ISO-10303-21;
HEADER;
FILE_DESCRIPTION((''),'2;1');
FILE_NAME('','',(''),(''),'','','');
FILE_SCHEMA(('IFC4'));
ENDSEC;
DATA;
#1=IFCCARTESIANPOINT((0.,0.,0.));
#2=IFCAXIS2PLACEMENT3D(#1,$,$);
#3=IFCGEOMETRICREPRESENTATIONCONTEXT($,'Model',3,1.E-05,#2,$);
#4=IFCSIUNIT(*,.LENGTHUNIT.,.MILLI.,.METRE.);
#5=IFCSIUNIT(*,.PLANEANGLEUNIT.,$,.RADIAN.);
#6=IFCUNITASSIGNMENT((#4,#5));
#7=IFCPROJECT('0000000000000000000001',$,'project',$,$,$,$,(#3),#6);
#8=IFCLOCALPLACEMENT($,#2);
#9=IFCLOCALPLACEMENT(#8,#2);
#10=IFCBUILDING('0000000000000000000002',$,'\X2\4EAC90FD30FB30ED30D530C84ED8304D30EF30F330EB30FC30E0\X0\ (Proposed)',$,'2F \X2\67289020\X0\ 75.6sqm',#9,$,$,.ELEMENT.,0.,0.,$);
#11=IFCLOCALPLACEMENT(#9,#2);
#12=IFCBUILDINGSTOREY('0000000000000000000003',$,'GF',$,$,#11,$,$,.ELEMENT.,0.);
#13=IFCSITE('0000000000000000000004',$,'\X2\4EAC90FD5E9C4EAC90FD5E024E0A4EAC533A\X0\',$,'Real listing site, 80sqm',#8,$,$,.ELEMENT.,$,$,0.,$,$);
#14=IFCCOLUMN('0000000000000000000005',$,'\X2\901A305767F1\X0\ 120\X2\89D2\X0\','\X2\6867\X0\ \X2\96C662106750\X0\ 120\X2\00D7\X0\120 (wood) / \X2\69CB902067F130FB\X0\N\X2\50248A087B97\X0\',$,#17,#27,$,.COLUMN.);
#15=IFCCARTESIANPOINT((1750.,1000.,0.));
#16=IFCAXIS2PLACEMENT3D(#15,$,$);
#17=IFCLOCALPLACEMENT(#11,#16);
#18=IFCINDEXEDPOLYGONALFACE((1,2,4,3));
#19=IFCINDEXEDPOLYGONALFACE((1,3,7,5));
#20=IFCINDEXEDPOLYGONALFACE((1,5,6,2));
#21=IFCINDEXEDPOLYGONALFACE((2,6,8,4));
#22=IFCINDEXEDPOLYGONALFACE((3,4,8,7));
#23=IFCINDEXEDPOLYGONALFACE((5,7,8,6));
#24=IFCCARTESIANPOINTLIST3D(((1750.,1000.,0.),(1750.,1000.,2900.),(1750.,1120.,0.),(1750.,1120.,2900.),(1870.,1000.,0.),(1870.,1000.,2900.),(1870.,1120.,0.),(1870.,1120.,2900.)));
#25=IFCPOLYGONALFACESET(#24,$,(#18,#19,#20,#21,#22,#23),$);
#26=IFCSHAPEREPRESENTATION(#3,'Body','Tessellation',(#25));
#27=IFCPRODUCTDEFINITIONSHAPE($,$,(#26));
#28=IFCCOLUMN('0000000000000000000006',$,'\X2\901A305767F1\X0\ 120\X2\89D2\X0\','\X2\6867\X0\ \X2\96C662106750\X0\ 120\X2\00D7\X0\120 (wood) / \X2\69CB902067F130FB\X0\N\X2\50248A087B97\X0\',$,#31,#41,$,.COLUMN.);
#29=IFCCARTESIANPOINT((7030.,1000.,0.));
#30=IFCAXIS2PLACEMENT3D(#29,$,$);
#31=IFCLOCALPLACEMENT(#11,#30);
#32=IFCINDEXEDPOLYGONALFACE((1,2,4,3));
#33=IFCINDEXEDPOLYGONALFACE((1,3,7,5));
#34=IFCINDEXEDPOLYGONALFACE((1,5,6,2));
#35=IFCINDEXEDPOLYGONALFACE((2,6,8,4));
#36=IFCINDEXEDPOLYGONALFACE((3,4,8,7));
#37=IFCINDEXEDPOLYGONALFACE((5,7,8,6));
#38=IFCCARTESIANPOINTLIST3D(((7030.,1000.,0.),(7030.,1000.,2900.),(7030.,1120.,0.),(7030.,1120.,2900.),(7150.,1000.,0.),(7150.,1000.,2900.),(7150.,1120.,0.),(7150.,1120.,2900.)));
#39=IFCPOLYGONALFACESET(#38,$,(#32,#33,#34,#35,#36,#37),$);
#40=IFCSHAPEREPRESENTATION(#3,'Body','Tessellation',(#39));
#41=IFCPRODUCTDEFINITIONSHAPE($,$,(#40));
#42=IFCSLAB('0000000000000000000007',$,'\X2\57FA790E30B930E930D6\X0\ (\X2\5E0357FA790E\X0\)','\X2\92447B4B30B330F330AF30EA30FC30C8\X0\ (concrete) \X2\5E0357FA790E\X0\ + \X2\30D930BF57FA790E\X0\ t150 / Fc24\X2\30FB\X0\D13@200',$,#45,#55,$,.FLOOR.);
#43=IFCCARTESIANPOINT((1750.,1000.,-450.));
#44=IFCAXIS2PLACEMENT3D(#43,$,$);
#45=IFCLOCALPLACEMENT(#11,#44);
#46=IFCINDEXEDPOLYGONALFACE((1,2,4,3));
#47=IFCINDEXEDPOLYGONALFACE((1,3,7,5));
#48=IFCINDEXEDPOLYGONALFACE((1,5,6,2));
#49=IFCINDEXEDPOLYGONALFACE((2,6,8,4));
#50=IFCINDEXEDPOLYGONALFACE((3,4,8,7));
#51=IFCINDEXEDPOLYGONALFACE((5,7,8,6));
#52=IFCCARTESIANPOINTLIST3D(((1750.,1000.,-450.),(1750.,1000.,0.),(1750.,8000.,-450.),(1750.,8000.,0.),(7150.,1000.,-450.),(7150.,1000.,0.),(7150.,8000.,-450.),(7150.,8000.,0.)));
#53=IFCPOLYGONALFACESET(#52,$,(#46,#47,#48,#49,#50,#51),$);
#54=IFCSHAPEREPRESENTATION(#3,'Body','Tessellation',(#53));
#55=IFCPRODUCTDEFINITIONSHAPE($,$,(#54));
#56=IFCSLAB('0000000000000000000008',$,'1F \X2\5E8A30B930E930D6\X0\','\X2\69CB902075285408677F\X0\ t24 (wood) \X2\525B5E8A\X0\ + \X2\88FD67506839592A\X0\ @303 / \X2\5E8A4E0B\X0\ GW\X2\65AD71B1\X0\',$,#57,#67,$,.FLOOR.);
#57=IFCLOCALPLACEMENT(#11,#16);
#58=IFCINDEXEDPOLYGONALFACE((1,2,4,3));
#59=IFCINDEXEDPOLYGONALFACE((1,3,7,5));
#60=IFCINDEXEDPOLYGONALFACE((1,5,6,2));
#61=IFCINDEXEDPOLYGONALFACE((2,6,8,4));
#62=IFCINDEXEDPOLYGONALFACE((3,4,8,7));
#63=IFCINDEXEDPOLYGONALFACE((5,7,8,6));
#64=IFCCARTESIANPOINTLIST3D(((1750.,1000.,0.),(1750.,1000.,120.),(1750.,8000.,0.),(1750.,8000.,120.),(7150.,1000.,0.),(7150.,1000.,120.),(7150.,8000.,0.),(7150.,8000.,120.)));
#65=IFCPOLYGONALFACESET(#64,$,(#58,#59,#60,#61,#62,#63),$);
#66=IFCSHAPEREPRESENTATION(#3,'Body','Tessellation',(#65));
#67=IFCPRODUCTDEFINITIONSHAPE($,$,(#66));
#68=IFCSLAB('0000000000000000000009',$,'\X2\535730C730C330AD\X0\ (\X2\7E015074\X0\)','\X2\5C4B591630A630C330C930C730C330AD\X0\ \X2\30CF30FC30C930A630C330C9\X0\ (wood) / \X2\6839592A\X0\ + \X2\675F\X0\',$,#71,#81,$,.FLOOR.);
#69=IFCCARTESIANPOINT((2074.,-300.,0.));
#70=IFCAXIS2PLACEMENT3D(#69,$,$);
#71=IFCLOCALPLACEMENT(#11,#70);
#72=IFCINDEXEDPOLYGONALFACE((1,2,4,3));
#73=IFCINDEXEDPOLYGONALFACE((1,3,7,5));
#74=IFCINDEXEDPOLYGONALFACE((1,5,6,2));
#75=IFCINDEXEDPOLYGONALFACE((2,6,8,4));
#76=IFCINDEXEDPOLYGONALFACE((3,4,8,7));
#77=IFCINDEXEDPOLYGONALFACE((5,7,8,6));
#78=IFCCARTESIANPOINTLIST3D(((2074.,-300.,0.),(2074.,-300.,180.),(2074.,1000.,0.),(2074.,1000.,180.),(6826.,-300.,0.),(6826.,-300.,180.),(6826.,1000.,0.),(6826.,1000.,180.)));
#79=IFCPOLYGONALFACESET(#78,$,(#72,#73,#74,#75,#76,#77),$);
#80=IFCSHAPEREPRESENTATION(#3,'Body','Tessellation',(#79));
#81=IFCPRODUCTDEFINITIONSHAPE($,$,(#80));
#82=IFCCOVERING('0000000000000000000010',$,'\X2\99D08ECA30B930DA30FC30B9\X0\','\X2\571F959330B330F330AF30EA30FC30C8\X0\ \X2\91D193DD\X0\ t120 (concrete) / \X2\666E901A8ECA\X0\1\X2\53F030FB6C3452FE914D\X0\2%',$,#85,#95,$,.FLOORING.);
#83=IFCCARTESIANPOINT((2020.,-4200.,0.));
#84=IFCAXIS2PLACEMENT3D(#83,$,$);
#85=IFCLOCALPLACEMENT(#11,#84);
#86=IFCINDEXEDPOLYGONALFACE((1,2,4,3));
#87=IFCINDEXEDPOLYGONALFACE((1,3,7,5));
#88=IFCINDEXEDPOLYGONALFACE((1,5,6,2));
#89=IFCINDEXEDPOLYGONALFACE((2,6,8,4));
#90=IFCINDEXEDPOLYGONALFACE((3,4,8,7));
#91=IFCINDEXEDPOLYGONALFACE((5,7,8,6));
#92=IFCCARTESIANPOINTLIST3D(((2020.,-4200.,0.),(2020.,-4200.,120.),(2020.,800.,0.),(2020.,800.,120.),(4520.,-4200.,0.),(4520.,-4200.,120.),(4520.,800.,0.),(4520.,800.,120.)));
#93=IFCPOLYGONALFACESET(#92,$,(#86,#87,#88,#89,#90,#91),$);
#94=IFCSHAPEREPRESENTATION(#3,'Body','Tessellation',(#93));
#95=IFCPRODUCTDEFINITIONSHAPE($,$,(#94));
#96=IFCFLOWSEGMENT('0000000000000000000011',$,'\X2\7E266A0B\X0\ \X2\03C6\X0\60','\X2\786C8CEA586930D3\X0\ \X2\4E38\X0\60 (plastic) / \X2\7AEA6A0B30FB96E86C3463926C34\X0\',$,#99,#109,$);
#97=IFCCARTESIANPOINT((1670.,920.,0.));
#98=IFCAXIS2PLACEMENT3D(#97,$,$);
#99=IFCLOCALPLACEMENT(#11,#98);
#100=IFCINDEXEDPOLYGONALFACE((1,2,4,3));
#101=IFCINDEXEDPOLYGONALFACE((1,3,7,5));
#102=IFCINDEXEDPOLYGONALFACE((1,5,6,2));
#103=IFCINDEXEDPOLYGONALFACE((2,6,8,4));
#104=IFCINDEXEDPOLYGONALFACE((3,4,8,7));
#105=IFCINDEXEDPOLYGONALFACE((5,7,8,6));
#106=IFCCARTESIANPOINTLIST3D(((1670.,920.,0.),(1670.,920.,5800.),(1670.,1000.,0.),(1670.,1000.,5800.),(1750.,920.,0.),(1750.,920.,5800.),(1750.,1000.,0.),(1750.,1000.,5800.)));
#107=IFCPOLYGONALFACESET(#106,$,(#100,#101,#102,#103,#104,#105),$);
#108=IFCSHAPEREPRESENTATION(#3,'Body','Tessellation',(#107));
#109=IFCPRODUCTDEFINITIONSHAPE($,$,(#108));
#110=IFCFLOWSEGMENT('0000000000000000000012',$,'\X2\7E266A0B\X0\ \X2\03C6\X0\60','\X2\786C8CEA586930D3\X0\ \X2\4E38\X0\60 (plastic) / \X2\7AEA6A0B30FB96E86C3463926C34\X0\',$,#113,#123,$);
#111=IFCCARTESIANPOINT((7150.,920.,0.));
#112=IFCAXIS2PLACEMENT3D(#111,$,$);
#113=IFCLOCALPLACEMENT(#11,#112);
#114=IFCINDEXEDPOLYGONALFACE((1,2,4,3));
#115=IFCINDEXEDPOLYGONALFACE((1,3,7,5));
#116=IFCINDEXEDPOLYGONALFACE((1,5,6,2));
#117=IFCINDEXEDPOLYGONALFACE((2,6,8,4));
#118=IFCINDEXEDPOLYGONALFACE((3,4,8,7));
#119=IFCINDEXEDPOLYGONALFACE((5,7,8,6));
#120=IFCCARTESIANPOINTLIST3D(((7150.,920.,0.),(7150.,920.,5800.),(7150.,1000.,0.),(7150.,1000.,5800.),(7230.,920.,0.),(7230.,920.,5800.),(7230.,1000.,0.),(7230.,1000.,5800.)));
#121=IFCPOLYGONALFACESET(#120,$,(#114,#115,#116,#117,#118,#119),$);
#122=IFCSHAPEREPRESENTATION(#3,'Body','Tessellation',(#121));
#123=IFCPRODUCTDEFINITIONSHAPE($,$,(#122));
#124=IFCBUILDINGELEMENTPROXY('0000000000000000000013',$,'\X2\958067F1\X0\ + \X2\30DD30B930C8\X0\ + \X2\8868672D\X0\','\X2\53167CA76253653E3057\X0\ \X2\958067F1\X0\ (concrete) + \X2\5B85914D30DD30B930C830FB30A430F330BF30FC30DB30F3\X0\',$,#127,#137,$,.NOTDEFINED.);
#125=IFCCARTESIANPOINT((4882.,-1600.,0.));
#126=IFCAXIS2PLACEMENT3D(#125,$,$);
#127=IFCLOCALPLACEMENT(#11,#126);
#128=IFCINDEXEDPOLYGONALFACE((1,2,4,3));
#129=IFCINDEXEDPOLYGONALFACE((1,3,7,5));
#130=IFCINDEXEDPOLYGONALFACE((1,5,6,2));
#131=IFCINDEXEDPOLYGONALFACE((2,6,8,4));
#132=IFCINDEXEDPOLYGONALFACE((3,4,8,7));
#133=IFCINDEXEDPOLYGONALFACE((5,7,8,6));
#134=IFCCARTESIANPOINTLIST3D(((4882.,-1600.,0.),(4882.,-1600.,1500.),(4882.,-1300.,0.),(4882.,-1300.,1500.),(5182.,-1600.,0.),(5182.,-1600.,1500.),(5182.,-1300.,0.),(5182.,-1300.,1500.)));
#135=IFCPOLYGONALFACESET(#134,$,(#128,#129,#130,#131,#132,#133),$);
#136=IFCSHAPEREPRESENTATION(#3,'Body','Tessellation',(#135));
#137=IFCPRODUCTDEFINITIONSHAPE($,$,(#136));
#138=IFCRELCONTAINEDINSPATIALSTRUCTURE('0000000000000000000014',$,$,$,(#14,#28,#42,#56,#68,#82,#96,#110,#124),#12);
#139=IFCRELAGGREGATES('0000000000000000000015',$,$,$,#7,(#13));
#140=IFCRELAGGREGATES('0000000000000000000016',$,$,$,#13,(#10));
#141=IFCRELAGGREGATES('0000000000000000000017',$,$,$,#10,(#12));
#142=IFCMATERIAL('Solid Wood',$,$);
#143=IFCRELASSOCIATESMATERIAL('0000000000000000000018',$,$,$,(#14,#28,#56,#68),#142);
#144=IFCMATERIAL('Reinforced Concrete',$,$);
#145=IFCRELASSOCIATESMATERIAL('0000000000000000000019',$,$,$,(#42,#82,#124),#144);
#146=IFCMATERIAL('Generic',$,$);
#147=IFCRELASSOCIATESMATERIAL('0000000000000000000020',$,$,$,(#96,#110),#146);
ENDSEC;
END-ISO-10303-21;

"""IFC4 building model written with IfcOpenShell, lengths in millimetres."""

from ifc_helpers import new_model, si_unit, frame, frame_2d, origin, place, context, project, spatial, rectangle, extrude, material, element, save


model = new_model("IFC4")

# Units and contexts
model_context = context("Model", 3, precision=1e-05, world=origin())
ifc_project = project(units=[si_unit("LENGTHUNIT", "METRE", prefix="MILLI"), si_unit("PLANEANGLEUNIT", "RADIAN")], contexts=[model_context])

# Site, building, storey
site_placement = place(None, origin())
site = spatial("IfcSite", under=ifc_project, at=site_placement, Name="京都府京都市上京区", ObjectType="Real listing site, 80sqm", CompositionType="ELEMENT", RefElevation=0.0)
building_placement = place(site_placement, origin())
building = spatial("IfcBuilding", under=site, at=building_placement, Name="京都・ロフト付きワンルーム (Proposed)", ObjectType="2F 木造 75.6sqm", CompositionType="ELEMENT", ElevationOfRefHeight=0.0, ElevationOfTerrain=0.0)
storey_placement = place(building_placement, origin())
storey = spatial("IfcBuildingStorey", under=building, at=storey_placement, Name="GF", CompositionType="ELEMENT", Elevation=0.0)

# Columns
ifc_material_1 = material(Name="Solid Wood")
column_1_placement = place(storey_placement, frame((1750.0, 1000.0, 0.0)))
element("IfcColumn", 1, at=column_1_placement, inside=storey, material=ifc_material_1, Name="通し柱 120角", Description="桧 集成材 120×120 (wood) / 構造柱・N値計算", PredefinedType="COLUMN", context=model_context, shape_type="SweptSolid", body=[
    extrude(rectangle(XDim=120.0, YDim=120.0, at=frame_2d((60.0, 60.0))), frame((1750.0, 1000.0, 0.0)), (0.0, 0.0, 1.0), 2900.0),
])
column_2_placement = place(storey_placement, frame((7030.0, 1000.0, 0.0)))
element("IfcColumn", 2, at=column_2_placement, inside=storey, material=ifc_material_1, Name="通し柱 120角", Description="桧 集成材 120×120 (wood) / 構造柱・N値計算", PredefinedType="COLUMN", context=model_context, shape_type="SweptSolid", body=[
    extrude(rectangle(XDim=120.0, YDim=120.0, at=frame_2d((60.0, 60.0))), frame((7030.0, 1000.0, 0.0)), (0.0, 0.0, 1.0), 2900.0),
])

# Slabs
ifc_material_2 = material(Name="Reinforced Concrete")
slab_1_placement = place(storey_placement, frame((1750.0, 1000.0, -450.0)))
element("IfcSlab", 3, at=slab_1_placement, inside=storey, material=ifc_material_2, Name="基礎スラブ (布基礎)", Description="鉄筋コンクリート (concrete) 布基礎 + ベタ基礎 t150 / Fc24・D13@200", PredefinedType="FLOOR", context=model_context, shape_type="SweptSolid", body=[
    extrude(rectangle(XDim=5400.0, YDim=7000.0, at=frame_2d((2700.0, 3500.0))), frame((1750.0, 1000.0, -450.0)), (0.0, 0.0, 1.0), 450.0),
])
slab_2_placement = place(storey_placement, frame((1750.0, 1000.0, 0.0)))
element("IfcSlab", 4, at=slab_2_placement, inside=storey, material=ifc_material_1, Name="1F 床スラブ", Description="構造用合板 t24 (wood) 剛床 + 製材根太 @303 / 床下 GW断熱", PredefinedType="FLOOR", context=model_context, shape_type="SweptSolid", body=[
    extrude(rectangle(XDim=5400.0, YDim=7000.0, at=frame_2d((2700.0, 3500.0))), frame((1750.0, 1000.0, 0.0)), (0.0, 0.0, 1.0), 120.0),
])
slab_3_placement = place(storey_placement, frame((2074.0, -300.0, 0.0)))
element("IfcSlab", 5, at=slab_3_placement, inside=storey, material=ifc_material_1, Name="南デッキ (縁側)", Description="屋外ウッドデッキ ハードウッド (wood) / 根太 + 束", PredefinedType="FLOOR", context=model_context, shape_type="SweptSolid", body=[
    extrude(rectangle(XDim=4752.0, YDim=1300.0, at=frame_2d((2376.0, 650.0))), frame((2074.0, -300.0, 0.0)), (0.0, 0.0, 1.0), 180.0),
])

# Covering
covering_1_placement = place(storey_placement, frame((2020.0, -4200.0, 0.0)))
element("IfcCovering", 6, at=covering_1_placement, inside=storey, material=ifc_material_2, Name="駐車スペース", Description="土間コンクリート 金鏝 t120 (concrete) / 普通車1台・水勾配2%", PredefinedType="FLOORING", context=model_context, shape_type="SweptSolid", body=[
    extrude(rectangle(XDim=2500.0, YDim=5000.0, at=frame_2d((1250.0, 2500.0))), frame((2020.0, -4200.0, 0.0)), (0.0, 0.0, 1.0), 120.0),
])

# Flow segments
ifc_material_3 = material(Name="Generic")
flow_segment_1_placement = place(storey_placement, frame((1670.0, 920.0, 0.0)))
element("IfcFlowSegment", 7, at=flow_segment_1_placement, inside=storey, material=ifc_material_3, Name="縦樋 φ60", Description="硬質塩ビ 丸60 (plastic) / 竪樋・雨水排水", context=model_context, shape_type="SweptSolid", body=[
    extrude(rectangle(XDim=80.0, YDim=80.0, at=frame_2d((40.0, 40.0))), frame((1670.0, 920.0, 0.0)), (0.0, 0.0, 1.0), 5800.0),
])
flow_segment_2_placement = place(storey_placement, frame((7150.0, 920.0, 0.0)))
element("IfcFlowSegment", 8, at=flow_segment_2_placement, inside=storey, material=ifc_material_3, Name="縦樋 φ60", Description="硬質塩ビ 丸60 (plastic) / 竪樋・雨水排水", context=model_context, shape_type="SweptSolid", body=[
    extrude(rectangle(XDim=80.0, YDim=80.0, at=frame_2d((40.0, 40.0))), frame((7150.0, 920.0, 0.0)), (0.0, 0.0, 1.0), 5800.0),
])

# Building element proxy
proxy_placement = place(storey_placement, frame((4882.0, -1600.0, 0.0)))
element("IfcBuildingElementProxy", 9, at=proxy_placement, inside=storey, material=ifc_material_2, Name="門柱 + ポスト + 表札", Description="化粧打放し 門柱 (concrete) + 宅配ポスト・インターホン", PredefinedType="NOTDEFINED", context=model_context, shape_type="SweptSolid", body=[
    extrude(rectangle(XDim=300.0, YDim=300.0, at=frame_2d((150.0, 150.0))), frame((4882.0, -1600.0, 0.0)), (0.0, 0.0, 1.0), 1500.0),
])

save(model, "model.ifc")
